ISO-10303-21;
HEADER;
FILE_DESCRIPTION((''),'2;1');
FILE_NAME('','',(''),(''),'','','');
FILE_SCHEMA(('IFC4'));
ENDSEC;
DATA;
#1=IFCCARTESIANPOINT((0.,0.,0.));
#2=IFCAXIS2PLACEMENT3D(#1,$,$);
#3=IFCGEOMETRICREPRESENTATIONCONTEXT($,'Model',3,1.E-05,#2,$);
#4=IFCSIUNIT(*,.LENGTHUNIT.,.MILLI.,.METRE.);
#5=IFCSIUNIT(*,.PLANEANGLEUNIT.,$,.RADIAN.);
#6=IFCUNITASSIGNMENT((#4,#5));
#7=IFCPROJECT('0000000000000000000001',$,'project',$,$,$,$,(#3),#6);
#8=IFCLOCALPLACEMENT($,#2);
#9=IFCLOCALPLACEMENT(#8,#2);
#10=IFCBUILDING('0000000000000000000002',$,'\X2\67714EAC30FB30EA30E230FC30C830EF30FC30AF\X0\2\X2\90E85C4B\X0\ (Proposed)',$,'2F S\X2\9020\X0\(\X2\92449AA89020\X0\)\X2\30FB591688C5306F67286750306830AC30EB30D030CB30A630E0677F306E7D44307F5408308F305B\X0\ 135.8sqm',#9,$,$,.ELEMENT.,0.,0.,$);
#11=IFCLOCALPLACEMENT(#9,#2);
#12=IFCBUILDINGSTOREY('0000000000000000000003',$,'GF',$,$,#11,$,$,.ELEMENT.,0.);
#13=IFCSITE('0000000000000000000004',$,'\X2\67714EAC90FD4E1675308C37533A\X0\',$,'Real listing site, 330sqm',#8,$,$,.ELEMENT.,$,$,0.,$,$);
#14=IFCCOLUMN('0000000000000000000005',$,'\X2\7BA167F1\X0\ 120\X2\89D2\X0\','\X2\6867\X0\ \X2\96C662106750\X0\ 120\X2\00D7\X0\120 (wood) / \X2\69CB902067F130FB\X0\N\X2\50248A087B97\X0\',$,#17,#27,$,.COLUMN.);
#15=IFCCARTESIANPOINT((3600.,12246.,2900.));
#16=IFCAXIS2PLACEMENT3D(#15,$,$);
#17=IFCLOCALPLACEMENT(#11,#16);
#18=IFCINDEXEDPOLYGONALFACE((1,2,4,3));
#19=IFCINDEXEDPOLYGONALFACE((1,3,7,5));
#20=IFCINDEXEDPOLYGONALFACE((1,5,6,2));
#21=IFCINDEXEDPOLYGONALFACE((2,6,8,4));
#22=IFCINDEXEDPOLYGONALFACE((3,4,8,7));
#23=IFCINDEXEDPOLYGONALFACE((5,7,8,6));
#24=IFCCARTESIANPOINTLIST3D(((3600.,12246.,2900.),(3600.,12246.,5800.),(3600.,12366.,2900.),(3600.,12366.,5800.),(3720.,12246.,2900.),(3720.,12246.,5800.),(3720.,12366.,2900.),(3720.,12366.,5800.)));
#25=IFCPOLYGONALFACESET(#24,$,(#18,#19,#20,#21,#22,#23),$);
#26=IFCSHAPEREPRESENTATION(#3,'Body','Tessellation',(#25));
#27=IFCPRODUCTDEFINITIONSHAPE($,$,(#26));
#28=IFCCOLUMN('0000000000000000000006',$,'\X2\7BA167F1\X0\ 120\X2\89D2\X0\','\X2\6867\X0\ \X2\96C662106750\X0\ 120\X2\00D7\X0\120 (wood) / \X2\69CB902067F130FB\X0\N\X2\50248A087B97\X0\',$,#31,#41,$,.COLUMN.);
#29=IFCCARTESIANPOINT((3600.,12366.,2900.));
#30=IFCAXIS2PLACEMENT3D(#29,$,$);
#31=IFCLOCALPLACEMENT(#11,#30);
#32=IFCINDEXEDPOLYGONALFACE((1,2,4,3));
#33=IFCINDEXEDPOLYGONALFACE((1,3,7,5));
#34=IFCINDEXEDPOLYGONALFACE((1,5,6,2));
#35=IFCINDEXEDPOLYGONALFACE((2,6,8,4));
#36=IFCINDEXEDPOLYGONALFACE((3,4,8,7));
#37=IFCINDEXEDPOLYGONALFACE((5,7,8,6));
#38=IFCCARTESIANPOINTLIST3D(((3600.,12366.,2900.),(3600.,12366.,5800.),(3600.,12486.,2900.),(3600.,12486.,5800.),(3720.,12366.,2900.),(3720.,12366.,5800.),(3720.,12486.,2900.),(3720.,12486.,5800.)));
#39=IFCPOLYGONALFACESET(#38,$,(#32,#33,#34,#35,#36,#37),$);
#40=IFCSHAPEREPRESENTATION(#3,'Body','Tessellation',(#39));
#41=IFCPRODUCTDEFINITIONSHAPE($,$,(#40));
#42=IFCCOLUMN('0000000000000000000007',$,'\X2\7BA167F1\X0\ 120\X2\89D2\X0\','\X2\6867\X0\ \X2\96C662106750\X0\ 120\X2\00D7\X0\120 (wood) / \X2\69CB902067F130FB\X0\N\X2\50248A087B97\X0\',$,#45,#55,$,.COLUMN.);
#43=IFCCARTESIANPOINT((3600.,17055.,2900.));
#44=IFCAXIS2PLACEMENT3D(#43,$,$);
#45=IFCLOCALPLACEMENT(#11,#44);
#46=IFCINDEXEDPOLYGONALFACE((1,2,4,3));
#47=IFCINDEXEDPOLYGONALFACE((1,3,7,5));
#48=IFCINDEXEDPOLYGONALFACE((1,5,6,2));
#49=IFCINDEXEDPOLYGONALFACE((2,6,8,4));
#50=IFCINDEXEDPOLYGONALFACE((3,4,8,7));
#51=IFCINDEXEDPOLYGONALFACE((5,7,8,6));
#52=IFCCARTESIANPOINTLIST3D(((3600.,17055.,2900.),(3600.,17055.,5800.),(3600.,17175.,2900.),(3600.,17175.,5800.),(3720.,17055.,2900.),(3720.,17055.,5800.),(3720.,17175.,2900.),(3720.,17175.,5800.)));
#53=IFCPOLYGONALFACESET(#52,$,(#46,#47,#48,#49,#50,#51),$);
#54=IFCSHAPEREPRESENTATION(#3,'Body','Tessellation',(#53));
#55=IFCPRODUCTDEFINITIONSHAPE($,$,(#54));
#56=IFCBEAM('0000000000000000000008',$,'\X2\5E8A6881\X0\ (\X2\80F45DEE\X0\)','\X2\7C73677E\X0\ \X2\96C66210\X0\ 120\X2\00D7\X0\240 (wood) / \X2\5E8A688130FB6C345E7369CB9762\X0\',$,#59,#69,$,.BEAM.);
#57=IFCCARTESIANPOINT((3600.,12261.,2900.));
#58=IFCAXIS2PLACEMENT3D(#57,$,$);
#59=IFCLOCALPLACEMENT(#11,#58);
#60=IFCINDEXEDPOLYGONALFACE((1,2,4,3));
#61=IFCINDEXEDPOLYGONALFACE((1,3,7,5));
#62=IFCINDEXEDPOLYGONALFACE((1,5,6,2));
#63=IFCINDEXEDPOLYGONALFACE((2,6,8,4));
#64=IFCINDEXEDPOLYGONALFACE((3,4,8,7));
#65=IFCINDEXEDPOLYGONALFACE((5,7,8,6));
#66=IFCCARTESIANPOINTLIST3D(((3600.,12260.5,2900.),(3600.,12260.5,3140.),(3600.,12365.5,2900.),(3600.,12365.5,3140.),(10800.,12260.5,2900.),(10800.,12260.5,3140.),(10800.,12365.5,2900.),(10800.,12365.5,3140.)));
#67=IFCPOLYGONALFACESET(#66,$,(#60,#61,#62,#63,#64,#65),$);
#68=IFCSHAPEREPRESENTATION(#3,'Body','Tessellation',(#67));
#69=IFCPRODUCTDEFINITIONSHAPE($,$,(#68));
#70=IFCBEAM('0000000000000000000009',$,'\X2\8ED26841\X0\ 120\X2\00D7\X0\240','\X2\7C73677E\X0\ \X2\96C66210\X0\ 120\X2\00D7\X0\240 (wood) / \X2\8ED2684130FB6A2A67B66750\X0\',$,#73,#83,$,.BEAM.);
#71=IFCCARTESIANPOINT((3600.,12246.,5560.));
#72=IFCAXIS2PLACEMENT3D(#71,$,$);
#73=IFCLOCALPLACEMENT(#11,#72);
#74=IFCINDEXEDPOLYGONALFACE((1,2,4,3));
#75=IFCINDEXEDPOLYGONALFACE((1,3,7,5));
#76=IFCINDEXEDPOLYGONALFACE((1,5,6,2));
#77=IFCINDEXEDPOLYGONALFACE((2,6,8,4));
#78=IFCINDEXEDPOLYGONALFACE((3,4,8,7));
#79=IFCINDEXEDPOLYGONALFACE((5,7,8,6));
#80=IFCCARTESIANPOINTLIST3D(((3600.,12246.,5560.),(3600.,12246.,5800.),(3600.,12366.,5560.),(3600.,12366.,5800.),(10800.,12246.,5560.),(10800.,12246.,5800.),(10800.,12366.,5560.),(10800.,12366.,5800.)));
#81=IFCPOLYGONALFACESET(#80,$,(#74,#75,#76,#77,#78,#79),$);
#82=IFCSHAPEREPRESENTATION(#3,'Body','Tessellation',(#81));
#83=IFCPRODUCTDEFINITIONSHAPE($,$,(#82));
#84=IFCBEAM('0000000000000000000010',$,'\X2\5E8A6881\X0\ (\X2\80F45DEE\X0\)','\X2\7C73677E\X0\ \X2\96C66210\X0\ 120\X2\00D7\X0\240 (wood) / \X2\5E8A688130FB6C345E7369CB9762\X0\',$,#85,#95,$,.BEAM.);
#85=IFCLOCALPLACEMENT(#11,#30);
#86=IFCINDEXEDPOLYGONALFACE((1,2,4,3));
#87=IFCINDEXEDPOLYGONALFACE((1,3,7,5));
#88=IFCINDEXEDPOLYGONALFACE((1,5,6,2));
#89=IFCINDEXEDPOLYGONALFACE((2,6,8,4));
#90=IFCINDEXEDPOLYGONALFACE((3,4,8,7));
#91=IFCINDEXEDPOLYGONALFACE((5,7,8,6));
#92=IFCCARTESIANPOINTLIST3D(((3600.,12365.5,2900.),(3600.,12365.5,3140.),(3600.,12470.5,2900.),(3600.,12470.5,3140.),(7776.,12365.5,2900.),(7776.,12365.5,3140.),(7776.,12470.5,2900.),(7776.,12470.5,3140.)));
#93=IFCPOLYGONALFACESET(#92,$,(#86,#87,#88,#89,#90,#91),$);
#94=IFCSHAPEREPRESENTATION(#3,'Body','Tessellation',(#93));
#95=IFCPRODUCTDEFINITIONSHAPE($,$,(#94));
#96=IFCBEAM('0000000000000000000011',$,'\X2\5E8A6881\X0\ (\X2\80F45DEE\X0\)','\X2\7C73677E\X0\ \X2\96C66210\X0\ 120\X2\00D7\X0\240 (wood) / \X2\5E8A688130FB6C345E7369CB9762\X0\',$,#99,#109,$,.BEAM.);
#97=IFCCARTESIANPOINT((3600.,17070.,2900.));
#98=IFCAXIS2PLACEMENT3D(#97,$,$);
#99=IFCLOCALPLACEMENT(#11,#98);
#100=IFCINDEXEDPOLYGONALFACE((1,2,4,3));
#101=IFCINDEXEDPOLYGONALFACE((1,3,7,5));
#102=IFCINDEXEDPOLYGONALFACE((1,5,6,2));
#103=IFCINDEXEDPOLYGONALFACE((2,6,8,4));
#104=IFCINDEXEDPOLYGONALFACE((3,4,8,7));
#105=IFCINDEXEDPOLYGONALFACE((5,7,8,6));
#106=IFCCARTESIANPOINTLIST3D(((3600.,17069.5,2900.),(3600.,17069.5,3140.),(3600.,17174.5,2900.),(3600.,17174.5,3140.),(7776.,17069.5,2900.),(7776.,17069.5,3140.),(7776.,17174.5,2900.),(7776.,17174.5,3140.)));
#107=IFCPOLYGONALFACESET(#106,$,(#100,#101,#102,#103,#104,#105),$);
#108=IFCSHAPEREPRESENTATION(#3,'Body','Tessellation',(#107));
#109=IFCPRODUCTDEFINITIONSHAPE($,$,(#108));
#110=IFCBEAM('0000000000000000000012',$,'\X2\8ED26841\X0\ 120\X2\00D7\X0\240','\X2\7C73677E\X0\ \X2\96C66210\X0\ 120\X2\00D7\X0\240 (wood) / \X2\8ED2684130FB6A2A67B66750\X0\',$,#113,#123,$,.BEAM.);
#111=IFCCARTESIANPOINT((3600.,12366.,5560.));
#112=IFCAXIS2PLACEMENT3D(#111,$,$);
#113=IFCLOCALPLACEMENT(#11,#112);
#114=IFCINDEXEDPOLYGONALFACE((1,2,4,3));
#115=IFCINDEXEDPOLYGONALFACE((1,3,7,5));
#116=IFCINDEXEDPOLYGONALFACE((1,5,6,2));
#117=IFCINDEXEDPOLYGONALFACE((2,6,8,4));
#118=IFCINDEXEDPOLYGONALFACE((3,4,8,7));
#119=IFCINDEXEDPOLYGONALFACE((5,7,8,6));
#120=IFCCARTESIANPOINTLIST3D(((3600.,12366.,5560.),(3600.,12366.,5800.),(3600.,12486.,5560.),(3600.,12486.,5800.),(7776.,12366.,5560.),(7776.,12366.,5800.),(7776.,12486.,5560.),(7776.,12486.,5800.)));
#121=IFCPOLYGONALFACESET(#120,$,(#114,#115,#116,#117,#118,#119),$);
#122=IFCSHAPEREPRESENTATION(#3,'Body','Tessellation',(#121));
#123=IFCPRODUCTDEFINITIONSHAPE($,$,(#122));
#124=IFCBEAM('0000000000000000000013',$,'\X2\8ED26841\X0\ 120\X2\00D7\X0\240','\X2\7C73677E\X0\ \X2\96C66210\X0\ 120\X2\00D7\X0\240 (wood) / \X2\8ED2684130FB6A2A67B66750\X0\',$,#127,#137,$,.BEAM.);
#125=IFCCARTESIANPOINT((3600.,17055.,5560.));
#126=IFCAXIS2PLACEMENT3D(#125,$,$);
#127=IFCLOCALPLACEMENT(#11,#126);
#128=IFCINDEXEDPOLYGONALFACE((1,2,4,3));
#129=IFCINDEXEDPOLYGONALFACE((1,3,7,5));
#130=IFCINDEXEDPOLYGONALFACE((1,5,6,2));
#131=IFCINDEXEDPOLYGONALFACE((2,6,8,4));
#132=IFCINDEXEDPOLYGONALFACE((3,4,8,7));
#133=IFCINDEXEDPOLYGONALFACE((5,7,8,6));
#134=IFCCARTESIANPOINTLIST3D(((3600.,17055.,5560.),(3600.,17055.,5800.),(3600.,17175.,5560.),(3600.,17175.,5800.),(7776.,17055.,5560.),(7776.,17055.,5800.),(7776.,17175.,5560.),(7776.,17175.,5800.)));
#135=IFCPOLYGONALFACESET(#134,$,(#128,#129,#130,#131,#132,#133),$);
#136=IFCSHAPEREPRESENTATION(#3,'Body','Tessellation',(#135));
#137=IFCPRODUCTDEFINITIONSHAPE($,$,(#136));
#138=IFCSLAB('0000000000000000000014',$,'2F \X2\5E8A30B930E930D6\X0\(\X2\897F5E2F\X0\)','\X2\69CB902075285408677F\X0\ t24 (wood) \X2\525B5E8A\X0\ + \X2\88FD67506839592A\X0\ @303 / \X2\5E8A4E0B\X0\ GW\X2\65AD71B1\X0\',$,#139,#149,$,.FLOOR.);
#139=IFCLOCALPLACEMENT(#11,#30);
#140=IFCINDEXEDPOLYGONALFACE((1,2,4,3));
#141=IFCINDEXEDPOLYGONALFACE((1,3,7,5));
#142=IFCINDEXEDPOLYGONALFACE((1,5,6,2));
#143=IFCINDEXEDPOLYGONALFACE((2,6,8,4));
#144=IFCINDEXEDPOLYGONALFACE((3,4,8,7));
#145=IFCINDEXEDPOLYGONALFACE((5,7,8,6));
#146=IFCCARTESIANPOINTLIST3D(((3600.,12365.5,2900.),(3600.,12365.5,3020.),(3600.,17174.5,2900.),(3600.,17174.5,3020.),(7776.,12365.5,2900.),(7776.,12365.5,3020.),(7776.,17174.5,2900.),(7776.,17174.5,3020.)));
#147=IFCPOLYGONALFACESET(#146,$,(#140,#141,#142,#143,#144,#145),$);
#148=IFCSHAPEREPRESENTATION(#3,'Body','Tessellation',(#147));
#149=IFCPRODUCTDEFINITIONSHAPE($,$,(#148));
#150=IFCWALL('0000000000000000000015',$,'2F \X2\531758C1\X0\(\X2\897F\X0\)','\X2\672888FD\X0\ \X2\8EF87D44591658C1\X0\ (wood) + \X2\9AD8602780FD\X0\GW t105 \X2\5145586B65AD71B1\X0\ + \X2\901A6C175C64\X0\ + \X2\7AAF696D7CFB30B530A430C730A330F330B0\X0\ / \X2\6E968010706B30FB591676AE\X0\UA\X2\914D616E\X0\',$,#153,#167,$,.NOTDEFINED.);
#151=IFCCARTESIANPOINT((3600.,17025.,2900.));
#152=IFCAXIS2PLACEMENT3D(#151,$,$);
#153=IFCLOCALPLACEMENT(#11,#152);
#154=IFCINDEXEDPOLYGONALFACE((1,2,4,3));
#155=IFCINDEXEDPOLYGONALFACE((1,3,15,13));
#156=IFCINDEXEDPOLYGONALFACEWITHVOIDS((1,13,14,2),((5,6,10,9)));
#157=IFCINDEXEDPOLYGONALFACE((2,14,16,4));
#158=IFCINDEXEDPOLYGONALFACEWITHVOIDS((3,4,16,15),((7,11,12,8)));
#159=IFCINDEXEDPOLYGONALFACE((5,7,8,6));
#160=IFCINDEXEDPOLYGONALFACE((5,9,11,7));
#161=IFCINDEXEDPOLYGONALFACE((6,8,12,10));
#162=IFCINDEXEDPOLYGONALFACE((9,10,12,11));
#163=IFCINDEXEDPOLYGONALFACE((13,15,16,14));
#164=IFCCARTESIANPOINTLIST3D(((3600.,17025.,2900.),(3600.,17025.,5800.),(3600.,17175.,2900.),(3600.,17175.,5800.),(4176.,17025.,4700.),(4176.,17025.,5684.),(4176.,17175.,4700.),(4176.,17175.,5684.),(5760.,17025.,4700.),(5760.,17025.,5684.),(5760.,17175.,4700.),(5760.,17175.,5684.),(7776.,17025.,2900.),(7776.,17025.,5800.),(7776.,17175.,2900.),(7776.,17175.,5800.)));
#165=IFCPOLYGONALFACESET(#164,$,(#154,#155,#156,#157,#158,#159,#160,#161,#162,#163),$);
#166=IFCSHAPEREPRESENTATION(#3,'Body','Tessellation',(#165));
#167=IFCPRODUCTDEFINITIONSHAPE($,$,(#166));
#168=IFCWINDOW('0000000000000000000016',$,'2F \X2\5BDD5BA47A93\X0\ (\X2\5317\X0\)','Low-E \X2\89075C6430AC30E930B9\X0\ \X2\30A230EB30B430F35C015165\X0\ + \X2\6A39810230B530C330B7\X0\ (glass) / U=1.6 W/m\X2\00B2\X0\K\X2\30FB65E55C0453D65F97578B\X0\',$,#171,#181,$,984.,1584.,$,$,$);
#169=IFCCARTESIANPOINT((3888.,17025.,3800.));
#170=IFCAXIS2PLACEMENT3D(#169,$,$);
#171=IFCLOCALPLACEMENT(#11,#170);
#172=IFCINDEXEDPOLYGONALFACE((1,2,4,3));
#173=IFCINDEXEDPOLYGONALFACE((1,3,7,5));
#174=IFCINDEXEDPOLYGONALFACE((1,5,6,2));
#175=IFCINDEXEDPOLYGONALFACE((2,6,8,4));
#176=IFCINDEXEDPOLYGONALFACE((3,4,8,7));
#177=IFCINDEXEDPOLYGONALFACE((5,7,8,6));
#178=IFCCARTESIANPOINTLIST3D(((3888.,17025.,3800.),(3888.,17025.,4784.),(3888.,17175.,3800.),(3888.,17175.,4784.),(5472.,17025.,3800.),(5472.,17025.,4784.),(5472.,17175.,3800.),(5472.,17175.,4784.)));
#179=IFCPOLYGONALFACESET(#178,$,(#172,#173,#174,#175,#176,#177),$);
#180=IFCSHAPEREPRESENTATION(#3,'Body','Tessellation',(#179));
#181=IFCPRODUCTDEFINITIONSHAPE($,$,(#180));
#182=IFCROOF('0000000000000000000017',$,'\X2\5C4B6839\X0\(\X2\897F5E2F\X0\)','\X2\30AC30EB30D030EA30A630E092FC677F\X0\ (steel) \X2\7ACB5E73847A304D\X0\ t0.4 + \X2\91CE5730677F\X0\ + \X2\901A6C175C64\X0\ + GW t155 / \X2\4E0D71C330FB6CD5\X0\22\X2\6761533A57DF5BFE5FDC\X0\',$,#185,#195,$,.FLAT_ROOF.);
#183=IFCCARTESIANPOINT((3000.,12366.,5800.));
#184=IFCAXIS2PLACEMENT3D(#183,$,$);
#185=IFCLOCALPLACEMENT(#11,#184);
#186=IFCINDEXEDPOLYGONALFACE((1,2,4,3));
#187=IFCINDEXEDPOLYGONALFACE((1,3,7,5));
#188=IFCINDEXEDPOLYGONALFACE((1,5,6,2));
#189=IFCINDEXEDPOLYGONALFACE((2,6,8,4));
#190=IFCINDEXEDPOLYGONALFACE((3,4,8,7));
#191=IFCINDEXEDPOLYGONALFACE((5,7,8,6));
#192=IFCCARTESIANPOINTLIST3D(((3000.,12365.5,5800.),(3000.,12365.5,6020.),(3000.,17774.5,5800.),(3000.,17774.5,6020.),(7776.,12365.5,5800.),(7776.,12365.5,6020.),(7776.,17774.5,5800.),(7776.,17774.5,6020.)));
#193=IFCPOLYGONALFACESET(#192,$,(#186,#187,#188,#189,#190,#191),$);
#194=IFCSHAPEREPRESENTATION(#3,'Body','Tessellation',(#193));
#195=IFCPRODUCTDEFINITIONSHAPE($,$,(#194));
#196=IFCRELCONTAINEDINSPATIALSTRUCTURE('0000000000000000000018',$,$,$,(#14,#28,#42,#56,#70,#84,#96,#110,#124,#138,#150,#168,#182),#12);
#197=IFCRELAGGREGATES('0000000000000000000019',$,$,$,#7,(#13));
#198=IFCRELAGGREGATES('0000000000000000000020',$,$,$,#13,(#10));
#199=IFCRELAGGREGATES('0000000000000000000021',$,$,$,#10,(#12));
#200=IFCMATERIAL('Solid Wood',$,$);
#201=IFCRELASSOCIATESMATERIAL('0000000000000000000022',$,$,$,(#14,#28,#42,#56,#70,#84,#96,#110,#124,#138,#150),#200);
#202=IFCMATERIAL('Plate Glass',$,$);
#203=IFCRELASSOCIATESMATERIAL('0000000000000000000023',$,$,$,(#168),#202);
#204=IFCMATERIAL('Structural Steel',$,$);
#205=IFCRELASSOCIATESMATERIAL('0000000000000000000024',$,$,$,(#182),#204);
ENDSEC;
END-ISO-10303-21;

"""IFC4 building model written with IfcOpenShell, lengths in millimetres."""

from ifc_helpers import new_model, si_unit, frame, frame_2d, origin, place, context, project, spatial, rectangle, extrude, material, element, fill, save


model = new_model("IFC4")

# Units and contexts
model_context = context("Model", 3, precision=1e-05, world=origin())
ifc_project = project(units=[si_unit("LENGTHUNIT", "METRE", prefix="MILLI"), si_unit("PLANEANGLEUNIT", "RADIAN")], contexts=[model_context])

# Site, building, storey
site_placement = place(None, origin())
site = spatial("IfcSite", under=ifc_project, at=site_placement, Name="東京都世田谷区", ObjectType="Real listing site, 330sqm", CompositionType="ELEMENT", RefElevation=0.0)
building_placement = place(site_placement, origin())
building = spatial("IfcBuilding", under=site, at=building_placement, Name="東京・リモートワーク2部屋 (Proposed)", ObjectType="2F S造(鉄骨造)・外装は木材とガルバニウム板の組み合わせ 135.8sqm", CompositionType="ELEMENT", ElevationOfRefHeight=0.0, ElevationOfTerrain=0.0)
storey_placement = place(building_placement, origin())
storey = spatial("IfcBuildingStorey", under=building, at=storey_placement, Name="GF", CompositionType="ELEMENT", Elevation=0.0)

# Columns
ifc_material_1 = material(Name="Solid Wood")
column_1_placement = place(storey_placement, frame((3600.0, 12246.0, 2900.0)))
element("IfcColumn", 1, at=column_1_placement, inside=storey, material=ifc_material_1, Name="管柱 120角", Description="桧 集成材 120×120 (wood) / 構造柱・N値計算", PredefinedType="COLUMN", context=model_context, shape_type="SweptSolid", body=[
    extrude(rectangle(XDim=120.0, YDim=120.0, at=frame_2d((60.0, 60.0))), frame((3600.0, 12246.0, 2900.0)), (0.0, 0.0, 1.0), 2900.0),
])
column_2_placement = place(storey_placement, frame((3600.0, 12366.0, 2900.0)))
element("IfcColumn", 2, at=column_2_placement, inside=storey, material=ifc_material_1, Name="管柱 120角", Description="桧 集成材 120×120 (wood) / 構造柱・N値計算", PredefinedType="COLUMN", context=model_context, shape_type="SweptSolid", body=[
    extrude(rectangle(XDim=120.0, YDim=120.0, at=frame_2d((60.0, 60.0))), frame((3600.0, 12366.0, 2900.0)), (0.0, 0.0, 1.0), 2900.0),
])
column_3_placement = place(storey_placement, frame((3600.0, 17055.0, 2900.0)))
element("IfcColumn", 3, at=column_3_placement, inside=storey, material=ifc_material_1, Name="管柱 120角", Description="桧 集成材 120×120 (wood) / 構造柱・N値計算", PredefinedType="COLUMN", context=model_context, shape_type="SweptSolid", body=[
    extrude(rectangle(XDim=120.0, YDim=120.0, at=frame_2d((60.0, 60.0))), frame((3600.0, 17055.0, 2900.0)), (0.0, 0.0, 1.0), 2900.0),
])

# Beams
beam_1_placement = place(storey_placement, frame((3600.0, 12261.0, 2900.0)))
element("IfcBeam", 4, at=beam_1_placement, inside=storey, material=ifc_material_1, Name="床梁 (胴差)", Description="米松 集成 120×240 (wood) / 床梁・水平構面", PredefinedType="BEAM", context=model_context, shape_type="SweptSolid", body=[
    extrude(rectangle(XDim=7200.0, YDim=105.0, at=frame_2d((3600.0, 52.0))), frame((3600.0, 12261.0, 2900.0)), (0.0, 0.0, 1.0), 240.0),
])
beam_2_placement = place(storey_placement, frame((3600.0, 12246.0, 5560.0)))
element("IfcBeam", 5, at=beam_2_placement, inside=storey, material=ifc_material_1, Name="軒桁 120×240", Description="米松 集成 120×240 (wood) / 軒桁・横架材", PredefinedType="BEAM", context=model_context, shape_type="SweptSolid", body=[
    extrude(rectangle(XDim=7200.0, YDim=120.0, at=frame_2d((3600.0, 60.0))), frame((3600.0, 12246.0, 5560.0)), (0.0, 0.0, 1.0), 240.0),
])
beam_3_placement = place(storey_placement, frame((3600.0, 12366.0, 2900.0)))
element("IfcBeam", 6, at=beam_3_placement, inside=storey, material=ifc_material_1, Name="床梁 (胴差)", Description="米松 集成 120×240 (wood) / 床梁・水平構面", PredefinedType="BEAM", context=model_context, shape_type="SweptSolid", body=[
    extrude(rectangle(XDim=4176.0, YDim=105.0, at=frame_2d((2088.0, 52.0))), frame((3600.0, 12366.0, 2900.0)), (0.0, 0.0, 1.0), 240.0),
])
beam_4_placement = place(storey_placement, frame((3600.0, 17070.0, 2900.0)))
element("IfcBeam", 7, at=beam_4_placement, inside=storey, material=ifc_material_1, Name="床梁 (胴差)", Description="米松 集成 120×240 (wood) / 床梁・水平構面", PredefinedType="BEAM", context=model_context, shape_type="SweptSolid", body=[
    extrude(rectangle(XDim=4176.0, YDim=105.0, at=frame_2d((2088.0, 52.0))), frame((3600.0, 17070.0, 2900.0)), (0.0, 0.0, 1.0), 240.0),
])
beam_5_placement = place(storey_placement, frame((3600.0, 12366.0, 5560.0)))
element("IfcBeam", 8, at=beam_5_placement, inside=storey, material=ifc_material_1, Name="軒桁 120×240", Description="米松 集成 120×240 (wood) / 軒桁・横架材", PredefinedType="BEAM", context=model_context, shape_type="SweptSolid", body=[
    extrude(rectangle(XDim=4176.0, YDim=120.0, at=frame_2d((2088.0, 60.0))), frame((3600.0, 12366.0, 5560.0)), (0.0, 0.0, 1.0), 240.0),
])
beam_6_placement = place(storey_placement, frame((3600.0, 17055.0, 5560.0)))
element("IfcBeam", 9, at=beam_6_placement, inside=storey, material=ifc_material_1, Name="軒桁 120×240", Description="米松 集成 120×240 (wood) / 軒桁・横架材", PredefinedType="BEAM", context=model_context, shape_type="SweptSolid", body=[
    extrude(rectangle(XDim=4176.0, YDim=120.0, at=frame_2d((2088.0, 60.0))), frame((3600.0, 17055.0, 5560.0)), (0.0, 0.0, 1.0), 240.0),
])

# Slab
slab_placement = place(storey_placement, frame((3600.0, 12366.0, 2900.0)))
element("IfcSlab", 10, at=slab_placement, inside=storey, material=ifc_material_1, Name="2F 床スラブ(西帯)", Description="構造用合板 t24 (wood) 剛床 + 製材根太 @303 / 床下 GW断熱", PredefinedType="FLOOR", context=model_context, shape_type="SweptSolid", body=[
    extrude(rectangle(XDim=4176.0, YDim=4809.0, at=frame_2d((2088.0, 2404.0))), frame((3600.0, 12366.0, 2900.0)), (0.0, 0.0, 1.0), 120.0),
])

# Wall, opening, window
wall_1_placement = place(storey_placement, frame((3600.0, 17025.0, 2900.0)))
wall_1 = element("IfcWall", 11, at=wall_1_placement, inside=storey, material=ifc_material_1, Name="2F 北壁(西)", Description="木製 軸組外壁 (wood) + 高性能GW t105 充填断熱 + 通気層 + 窯業系サイディング / 準耐火・外皮UA配慮", PredefinedType="NOTDEFINED", context=model_context, shape_type="SweptSolid", body=[
    extrude(rectangle(XDim=4176.0, YDim=150.0, at=frame_2d((2088.0, 75.0))), frame((3600.0, 17025.0, 2900.0)), (0.0, 0.0, 1.0), 2900.0),
])
opening_placement = place(storey_placement, frame((3888.0, 17025.0, 3800.0)))
opening = element("IfcOpeningElement", 12, at=opening_placement, cuts=wall_1, PredefinedType="NOTDEFINED", context=model_context, shape_type="SweptSolid", body=[
    extrude(rectangle(XDim=1584.0, YDim=150.0, at=frame_2d((792.0, 75.0))), frame((3888.0, 17025.0, 3800.0)), (0.0, 0.0, 1.0), 984.0),
])
ifc_material_2 = material(Name="Plate Glass")
window_placement = place(storey_placement, frame((3888.0, 17025.0, 3800.0)))
window = element("IfcWindow", 13, at=window_placement, inside=storey, material=ifc_material_2, Name="2F 寝室窓 (北)", Description="Low-E 複層ガラス アルゴン封入 + 樹脂サッシ (glass) / U=1.6 W/m²K・日射取得型", OverallHeight=984.0, OverallWidth=1584.0, context=model_context, shape_type="SweptSolid", body=[
    extrude(rectangle(XDim=1584.0, YDim=150.0, at=frame_2d((792.0, 75.0))), frame((3888.0, 17025.0, 3800.0)), (0.0, 0.0, 1.0), 984.0),
])
fill(opening, window)

# Roof
ifc_material_3 = material(Name="Structural Steel")
for number, where, name in (
    (14, (3000.0, 12366.0, 5800.0), "屋根(西帯)"),
):
    element("IfcRoof", number, at=place(storey_placement, frame(where)), inside=storey, material=ifc_material_3, Name=name, Description="ガルバリウム鋼板 (steel) 立平葺き t0.4 + 野地板 + 通気層 + GW t155 / 不燃・法22条区域対応", PredefinedType="FLAT_ROOF", context=model_context, shape_type="SweptSolid", body=[
        extrude(rectangle(XDim=4776.0, YDim=5409.0, at=frame_2d((2388.0, 2704.0))), frame((3000.0, 12366.0, 5800.0)), (0.0, 0.0, 1.0), 220.0),
    ])

save(model, "model.ifc")
